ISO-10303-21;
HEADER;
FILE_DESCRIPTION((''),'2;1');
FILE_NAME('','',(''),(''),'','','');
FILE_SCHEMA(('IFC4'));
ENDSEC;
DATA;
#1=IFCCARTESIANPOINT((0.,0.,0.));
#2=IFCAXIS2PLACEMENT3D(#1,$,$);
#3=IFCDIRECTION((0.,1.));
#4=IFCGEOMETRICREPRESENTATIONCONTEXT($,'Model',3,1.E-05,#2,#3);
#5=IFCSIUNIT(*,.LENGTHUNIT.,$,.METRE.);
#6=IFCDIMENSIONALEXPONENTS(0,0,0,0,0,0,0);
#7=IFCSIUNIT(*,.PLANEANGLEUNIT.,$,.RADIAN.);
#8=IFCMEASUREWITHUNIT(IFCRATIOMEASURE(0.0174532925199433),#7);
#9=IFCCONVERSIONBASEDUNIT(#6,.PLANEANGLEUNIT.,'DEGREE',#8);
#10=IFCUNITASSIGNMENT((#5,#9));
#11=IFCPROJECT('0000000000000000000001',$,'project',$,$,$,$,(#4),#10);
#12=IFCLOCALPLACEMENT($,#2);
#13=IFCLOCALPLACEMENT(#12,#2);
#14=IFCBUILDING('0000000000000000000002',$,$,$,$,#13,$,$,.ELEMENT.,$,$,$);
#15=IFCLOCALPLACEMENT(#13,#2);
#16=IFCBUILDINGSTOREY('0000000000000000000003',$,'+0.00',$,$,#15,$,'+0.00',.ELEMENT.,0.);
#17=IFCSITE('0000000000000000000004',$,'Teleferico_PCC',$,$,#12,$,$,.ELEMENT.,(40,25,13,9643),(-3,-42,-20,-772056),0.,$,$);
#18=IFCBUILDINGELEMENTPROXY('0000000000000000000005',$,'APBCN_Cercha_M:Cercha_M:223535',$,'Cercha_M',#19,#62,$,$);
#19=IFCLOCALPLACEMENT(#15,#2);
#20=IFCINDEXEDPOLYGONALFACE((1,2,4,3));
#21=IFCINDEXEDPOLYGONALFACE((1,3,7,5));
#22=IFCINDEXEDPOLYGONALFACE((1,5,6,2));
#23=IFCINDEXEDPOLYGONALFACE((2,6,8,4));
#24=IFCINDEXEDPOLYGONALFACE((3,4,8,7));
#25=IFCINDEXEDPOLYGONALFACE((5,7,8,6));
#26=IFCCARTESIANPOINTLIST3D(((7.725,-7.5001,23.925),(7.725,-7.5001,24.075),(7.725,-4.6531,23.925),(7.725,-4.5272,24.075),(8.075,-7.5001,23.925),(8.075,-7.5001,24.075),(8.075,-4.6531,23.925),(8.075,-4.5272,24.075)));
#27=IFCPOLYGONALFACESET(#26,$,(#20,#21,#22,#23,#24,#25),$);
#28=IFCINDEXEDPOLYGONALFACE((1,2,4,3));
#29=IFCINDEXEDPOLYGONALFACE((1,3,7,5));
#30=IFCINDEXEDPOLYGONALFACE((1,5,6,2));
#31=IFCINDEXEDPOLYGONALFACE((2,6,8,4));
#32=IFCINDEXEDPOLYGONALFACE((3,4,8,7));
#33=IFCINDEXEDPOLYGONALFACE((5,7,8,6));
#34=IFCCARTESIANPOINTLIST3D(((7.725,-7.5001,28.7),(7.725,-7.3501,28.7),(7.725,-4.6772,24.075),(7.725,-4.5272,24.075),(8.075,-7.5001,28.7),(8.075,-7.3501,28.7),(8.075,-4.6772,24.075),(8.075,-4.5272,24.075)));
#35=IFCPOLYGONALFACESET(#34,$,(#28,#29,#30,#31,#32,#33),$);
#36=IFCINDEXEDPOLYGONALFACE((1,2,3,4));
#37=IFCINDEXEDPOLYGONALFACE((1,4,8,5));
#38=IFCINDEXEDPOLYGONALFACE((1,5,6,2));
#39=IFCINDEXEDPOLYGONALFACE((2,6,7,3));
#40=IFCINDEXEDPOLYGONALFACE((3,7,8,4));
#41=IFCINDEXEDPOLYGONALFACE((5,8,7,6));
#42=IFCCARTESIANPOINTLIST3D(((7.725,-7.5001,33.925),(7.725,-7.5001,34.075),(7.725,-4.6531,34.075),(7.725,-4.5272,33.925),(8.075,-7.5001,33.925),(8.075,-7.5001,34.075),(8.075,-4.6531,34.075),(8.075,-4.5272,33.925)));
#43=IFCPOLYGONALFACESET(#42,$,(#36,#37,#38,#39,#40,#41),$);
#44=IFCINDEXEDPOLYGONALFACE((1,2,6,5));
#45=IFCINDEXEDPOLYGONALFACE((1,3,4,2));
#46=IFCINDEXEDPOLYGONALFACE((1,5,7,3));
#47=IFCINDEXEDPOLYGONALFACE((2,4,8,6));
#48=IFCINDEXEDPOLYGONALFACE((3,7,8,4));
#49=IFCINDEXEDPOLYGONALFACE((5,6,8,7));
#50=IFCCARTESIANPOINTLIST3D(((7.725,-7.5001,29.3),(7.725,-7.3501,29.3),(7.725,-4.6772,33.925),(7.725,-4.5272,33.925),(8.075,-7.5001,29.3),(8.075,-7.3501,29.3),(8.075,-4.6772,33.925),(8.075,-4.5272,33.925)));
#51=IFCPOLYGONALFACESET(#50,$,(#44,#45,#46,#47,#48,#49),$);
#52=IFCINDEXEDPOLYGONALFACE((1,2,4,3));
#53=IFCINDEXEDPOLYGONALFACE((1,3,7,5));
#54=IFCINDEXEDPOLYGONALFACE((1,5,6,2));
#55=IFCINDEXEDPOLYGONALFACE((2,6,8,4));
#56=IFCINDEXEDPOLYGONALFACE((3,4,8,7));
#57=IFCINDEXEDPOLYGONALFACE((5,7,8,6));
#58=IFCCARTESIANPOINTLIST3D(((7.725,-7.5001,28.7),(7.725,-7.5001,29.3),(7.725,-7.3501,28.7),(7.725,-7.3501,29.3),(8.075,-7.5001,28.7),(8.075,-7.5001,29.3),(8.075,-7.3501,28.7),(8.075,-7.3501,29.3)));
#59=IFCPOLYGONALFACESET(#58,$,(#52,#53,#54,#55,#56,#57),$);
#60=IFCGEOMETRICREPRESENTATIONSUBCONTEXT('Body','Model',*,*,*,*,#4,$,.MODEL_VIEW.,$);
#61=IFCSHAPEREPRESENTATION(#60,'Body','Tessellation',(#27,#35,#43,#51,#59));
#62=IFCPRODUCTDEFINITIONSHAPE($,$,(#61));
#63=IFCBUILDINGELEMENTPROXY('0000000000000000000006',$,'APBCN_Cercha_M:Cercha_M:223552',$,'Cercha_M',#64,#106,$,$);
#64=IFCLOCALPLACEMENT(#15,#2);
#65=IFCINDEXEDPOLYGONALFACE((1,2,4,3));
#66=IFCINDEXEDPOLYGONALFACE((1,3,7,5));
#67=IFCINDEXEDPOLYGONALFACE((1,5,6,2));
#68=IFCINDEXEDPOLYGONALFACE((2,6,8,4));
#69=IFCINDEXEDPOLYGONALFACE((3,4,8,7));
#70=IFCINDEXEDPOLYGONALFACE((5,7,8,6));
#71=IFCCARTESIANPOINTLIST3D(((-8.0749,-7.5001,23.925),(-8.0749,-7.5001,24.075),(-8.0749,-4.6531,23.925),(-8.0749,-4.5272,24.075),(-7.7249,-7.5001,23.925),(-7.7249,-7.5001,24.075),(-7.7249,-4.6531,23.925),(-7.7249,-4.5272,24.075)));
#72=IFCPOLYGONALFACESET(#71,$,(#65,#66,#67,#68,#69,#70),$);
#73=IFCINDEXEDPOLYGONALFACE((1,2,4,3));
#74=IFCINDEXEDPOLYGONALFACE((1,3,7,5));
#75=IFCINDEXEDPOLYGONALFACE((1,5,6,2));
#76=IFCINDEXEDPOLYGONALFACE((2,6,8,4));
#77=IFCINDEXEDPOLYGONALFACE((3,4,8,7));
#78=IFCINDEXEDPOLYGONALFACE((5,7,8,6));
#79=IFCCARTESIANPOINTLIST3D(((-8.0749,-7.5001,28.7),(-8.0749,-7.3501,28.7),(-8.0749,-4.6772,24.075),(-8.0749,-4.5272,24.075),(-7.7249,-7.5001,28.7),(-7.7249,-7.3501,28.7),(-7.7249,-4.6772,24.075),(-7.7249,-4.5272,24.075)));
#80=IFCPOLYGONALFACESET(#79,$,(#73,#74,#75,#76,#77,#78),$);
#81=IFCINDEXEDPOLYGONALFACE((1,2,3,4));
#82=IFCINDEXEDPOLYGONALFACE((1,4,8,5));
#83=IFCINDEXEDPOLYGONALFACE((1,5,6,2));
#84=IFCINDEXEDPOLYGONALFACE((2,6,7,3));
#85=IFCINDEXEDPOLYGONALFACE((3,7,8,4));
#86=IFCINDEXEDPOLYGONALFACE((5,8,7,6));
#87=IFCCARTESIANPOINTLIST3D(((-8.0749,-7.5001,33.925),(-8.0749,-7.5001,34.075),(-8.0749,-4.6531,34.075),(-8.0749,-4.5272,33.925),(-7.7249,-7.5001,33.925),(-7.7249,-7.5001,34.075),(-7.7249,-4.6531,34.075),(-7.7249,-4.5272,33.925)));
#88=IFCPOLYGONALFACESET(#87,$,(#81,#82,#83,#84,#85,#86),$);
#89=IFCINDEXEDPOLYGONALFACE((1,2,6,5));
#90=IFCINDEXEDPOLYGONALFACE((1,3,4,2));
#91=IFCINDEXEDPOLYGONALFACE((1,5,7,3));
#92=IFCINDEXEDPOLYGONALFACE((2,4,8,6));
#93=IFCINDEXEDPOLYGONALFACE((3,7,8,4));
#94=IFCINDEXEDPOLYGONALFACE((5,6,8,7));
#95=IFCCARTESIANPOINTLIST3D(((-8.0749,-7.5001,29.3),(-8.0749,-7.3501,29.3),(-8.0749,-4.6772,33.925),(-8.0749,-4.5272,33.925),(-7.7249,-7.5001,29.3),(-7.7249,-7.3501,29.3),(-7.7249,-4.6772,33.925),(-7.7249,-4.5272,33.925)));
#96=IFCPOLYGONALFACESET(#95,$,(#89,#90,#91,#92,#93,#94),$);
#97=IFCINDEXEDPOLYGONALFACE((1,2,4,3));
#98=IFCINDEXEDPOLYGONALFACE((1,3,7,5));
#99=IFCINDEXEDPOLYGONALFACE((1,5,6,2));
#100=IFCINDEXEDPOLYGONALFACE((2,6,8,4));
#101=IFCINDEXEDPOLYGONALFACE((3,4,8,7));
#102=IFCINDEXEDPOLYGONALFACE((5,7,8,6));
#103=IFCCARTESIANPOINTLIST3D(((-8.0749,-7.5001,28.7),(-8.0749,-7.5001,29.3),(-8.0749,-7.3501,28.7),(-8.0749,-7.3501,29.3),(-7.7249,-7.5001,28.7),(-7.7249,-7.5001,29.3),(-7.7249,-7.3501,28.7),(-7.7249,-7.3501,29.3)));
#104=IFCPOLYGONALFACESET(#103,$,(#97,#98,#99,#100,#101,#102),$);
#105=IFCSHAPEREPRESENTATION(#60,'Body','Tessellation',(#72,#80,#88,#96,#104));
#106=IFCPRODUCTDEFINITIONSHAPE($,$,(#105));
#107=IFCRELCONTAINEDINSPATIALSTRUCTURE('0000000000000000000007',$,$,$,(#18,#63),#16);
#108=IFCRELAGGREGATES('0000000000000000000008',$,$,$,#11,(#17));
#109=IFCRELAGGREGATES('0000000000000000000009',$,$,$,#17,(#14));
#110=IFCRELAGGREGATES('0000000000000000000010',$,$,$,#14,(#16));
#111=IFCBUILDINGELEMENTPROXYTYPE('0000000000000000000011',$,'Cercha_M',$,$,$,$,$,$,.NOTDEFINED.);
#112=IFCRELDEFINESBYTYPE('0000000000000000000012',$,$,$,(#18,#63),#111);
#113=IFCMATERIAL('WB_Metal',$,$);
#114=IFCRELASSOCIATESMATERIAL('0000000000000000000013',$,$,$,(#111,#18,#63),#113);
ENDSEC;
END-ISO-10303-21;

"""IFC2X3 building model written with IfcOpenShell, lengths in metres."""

from ifc_helpers import new_model, entity, si_unit, converted_unit, direction, frame, origin, origin_2d_with_axis, place, context, subcontext, project, spatial, polyline, rectangle, outline, extrude, source, transform, mapped, material, type_object, type_shapes, element, save


model = new_model("IFC2X3")

# Units and contexts
model_context = context("Model", 3, precision=1e-05, world=origin(), true_north=direction((0.0, 1.0)))
body_context = subcontext(model_context, "Body", "Model", "MODEL_VIEW")
ifc_project = project(units=[si_unit("LENGTHUNIT", "METRE"), converted_unit("PLANEANGLEUNIT", "DEGREE", entity("IfcRatioMeasure", 0.0174532925199433), si_unit("PLANEANGLEUNIT", "RADIAN"), dimensions=[0, 0, 0, 0, 0, 0, 0])], contexts=[model_context])

# Site, building, storey
site_placement = place(None, origin())
site = spatial("IfcSite", under=ifc_project, at=site_placement, Name="Teleferico_PCC", CompositionType="ELEMENT", RefLatitude=(40, 25, 13, 9643), RefLongitude=(-3, -42, -20, -772056), RefElevation=0.0)
building_placement = place(site_placement, origin())
building = spatial("IfcBuilding", under=site, at=building_placement, CompositionType="ELEMENT")
storey_placement = place(building_placement, origin())
storey = spatial("IfcBuildingStorey", under=building, at=storey_placement, Name="+0.00", LongName="+0.00", CompositionType="ELEMENT", Elevation=0.0)

# Shared definitions
ifc_material = material(Name="WB_Metal")

# Building element proxies
building_element_proxy_type_1 = type_object("IfcBuildingElementProxyType", Name="Cercha_M", PredefinedType="NOTDEFINED", material=ifc_material)
shared_shape_1 = source(origin(), body_context, "Body", "SweptSolid", [
    extrude(outline(polyline([(-0.075, -1.455), (0.075, -1.455), (0.075, 1.3921), (-0.075, 1.5179), (-0.075, -1.455)])), frame((-1.455, -0.175, -5.0), z_axis=(0.0, 1.0, 0.0), x_axis=(0.0, 0.0, -1.0)), (0.0, 0.0, 1.0), 0.35),
    extrude(outline(polyline([(1.3365, -2.3125), (1.4865, -2.3125), (-1.3365, 2.3125), (-1.4865, 2.3125), (1.3365, -2.3125)])), frame((-1.4865, -0.175, -2.6125), z_axis=(0.0, 1.0, 0.0), x_axis=(1.0, 0.0, 0.0)), (0.0, 0.0, 1.0), 0.35),
    extrude(outline(polyline([(-0.075, -1.455), (0.075, -1.455), (0.075, 1.5179), (-0.075, 1.3921), (-0.075, -1.455)])), frame((-1.455, -0.175, 5.0), z_axis=(0.0, 1.0, 0.0), x_axis=(0.0, 0.0, -1.0)), (0.0, 0.0, 1.0), 0.35),
    extrude(outline(polyline([(-2.6701, -0.064), (2.7483, -0.064), (2.6701, 0.064), (-2.7483, 0.064), (-2.6701, -0.064)])), frame((-1.4865, -0.175, 2.6125), z_axis=(0.0, 1.0, 0.0), x_axis=(-0.520985, 0.0, 0.853566)), (0.0, 0.0, 1.0), 0.35),
    extrude(rectangle(XDim=0.15, YDim=0.35, at=origin_2d_with_axis()), frame((-0.075, 0.0, -0.3), z_axis=(0.0, 0.0, 1.0), x_axis=(-1.0, 0.0, 0.0)), (0.0, 0.0, 1.0), 0.6),
])
type_shapes(building_element_proxy_type_1, [shared_shape_1])
for number, where, z_axis, x_axis, name in (
    (1, (7.9, -7.5001, 29.0), (0.0, 0.0, 1.0), (0.0, -1.0, 0.0), "APBCN_Cercha_M:Cercha_M:223535"),
    (2, (-7.8999, -7.5001, 29.0), (0.0, 0.0, 1.0), (0.0, -1.0, 0.0), "APBCN_Cercha_M:Cercha_M:223552"),
):
    element("IfcBuildingElementProxy", number, at=place(storey_placement, frame(where, z_axis=z_axis, x_axis=x_axis)), inside=storey, type_object=building_element_proxy_type_1, material=ifc_material, Name=name, ObjectType="Cercha_M", context=body_context, shape_type="MappedRepresentation", body=[
        mapped(shared_shape_1, transform((0.0, 0.0, 0.0), scale=1.0)),
    ])

save(model, "model.ifc")
